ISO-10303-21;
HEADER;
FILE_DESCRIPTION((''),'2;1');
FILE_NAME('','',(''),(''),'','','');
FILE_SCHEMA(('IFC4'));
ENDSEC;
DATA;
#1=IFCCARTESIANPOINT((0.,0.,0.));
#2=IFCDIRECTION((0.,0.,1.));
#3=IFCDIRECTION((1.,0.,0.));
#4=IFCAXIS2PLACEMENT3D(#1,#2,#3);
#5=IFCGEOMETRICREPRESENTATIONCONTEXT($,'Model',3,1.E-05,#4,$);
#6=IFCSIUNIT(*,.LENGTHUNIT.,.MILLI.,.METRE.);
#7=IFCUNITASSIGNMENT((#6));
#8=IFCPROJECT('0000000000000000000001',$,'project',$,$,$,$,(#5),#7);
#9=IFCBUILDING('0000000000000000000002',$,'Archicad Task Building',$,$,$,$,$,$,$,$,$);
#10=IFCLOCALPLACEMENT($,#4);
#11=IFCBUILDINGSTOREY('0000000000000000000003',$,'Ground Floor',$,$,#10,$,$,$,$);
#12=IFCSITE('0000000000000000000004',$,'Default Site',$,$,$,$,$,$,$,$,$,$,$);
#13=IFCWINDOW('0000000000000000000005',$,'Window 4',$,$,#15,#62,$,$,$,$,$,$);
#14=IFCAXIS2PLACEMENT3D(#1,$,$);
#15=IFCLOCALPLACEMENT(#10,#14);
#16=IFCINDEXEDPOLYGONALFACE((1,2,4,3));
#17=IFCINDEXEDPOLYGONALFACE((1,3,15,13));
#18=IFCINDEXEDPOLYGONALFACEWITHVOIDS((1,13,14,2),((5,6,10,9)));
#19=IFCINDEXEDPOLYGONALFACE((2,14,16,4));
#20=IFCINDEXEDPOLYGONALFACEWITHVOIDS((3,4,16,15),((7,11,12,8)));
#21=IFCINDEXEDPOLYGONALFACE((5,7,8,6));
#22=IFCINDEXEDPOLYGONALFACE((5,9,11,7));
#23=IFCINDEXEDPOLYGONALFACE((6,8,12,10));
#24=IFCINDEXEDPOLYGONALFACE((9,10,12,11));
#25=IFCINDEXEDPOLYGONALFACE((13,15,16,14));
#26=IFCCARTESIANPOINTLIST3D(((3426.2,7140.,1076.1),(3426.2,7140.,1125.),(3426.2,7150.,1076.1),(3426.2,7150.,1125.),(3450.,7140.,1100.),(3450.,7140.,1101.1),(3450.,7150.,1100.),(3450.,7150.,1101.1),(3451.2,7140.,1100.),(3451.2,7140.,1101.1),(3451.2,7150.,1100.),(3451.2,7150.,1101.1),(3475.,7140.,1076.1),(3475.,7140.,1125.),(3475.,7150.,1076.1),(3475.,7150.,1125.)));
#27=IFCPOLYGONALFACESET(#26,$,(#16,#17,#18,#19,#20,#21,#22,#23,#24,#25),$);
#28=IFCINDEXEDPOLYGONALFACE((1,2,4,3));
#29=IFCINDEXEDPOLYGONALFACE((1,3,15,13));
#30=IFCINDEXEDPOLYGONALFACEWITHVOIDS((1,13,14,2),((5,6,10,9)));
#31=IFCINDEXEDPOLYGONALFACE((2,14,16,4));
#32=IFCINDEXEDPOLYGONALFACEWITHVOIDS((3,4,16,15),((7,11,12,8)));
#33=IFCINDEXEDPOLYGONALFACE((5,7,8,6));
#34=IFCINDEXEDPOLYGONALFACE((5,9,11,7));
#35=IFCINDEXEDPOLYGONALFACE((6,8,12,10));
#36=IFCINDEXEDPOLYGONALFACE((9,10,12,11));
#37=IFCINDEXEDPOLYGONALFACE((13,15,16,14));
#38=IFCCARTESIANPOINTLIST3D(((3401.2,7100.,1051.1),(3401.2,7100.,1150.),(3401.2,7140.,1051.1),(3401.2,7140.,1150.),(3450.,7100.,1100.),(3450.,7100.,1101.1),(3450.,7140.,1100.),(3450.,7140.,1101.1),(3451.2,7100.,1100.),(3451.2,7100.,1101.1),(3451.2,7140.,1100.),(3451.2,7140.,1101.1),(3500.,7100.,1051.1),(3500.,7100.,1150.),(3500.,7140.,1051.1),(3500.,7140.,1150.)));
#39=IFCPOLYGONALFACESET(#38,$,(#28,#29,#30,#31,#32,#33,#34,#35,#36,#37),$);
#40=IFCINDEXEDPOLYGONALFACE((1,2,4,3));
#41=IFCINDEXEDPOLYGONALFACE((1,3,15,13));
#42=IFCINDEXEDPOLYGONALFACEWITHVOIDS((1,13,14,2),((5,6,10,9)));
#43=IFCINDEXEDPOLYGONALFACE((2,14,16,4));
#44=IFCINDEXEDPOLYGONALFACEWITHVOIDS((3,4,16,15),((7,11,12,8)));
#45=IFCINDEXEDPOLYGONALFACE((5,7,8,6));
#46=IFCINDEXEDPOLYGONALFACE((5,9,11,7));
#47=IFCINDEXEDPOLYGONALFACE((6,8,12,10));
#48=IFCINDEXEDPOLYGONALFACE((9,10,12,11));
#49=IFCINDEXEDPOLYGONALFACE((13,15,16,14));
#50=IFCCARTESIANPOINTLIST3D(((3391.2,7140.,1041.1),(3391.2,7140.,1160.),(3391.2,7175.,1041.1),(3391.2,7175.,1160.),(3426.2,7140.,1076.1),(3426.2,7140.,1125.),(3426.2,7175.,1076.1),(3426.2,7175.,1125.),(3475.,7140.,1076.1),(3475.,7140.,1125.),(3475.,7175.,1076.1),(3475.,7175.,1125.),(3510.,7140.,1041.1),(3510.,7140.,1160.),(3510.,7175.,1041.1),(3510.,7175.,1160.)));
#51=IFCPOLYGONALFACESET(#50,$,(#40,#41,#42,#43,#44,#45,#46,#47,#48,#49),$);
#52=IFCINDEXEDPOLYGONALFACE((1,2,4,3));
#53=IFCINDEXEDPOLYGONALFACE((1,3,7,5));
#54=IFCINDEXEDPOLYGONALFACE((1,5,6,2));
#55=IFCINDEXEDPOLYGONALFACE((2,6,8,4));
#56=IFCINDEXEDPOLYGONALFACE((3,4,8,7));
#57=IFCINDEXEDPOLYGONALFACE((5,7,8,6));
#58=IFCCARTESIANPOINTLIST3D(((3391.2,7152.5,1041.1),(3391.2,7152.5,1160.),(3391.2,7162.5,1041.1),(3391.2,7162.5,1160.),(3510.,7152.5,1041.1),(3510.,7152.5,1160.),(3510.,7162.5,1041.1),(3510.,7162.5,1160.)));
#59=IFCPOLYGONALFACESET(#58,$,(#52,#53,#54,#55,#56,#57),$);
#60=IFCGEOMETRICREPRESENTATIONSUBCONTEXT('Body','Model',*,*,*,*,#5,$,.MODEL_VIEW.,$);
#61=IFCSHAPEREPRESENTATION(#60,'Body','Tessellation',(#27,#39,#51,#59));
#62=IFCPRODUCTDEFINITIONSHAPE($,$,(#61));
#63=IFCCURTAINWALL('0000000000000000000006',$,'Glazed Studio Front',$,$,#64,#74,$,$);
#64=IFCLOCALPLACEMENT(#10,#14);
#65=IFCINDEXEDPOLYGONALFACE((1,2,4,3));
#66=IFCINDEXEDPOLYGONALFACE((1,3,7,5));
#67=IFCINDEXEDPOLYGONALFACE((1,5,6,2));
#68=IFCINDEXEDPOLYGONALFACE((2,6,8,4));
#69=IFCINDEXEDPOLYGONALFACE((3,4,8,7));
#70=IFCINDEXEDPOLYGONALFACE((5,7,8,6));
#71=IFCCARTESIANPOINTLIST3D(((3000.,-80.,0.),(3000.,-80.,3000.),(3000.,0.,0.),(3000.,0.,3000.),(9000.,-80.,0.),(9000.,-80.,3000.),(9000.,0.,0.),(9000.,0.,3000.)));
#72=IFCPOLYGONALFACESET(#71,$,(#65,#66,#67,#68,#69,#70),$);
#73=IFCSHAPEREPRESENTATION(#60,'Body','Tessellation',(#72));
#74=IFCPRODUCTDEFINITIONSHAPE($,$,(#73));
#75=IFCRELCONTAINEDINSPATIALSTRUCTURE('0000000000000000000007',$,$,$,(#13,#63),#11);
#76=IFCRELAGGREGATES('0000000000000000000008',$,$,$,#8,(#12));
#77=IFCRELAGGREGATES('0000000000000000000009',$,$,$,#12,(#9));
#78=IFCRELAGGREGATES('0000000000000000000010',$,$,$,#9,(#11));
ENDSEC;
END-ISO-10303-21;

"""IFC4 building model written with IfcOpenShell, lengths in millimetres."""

from ifc_helpers import new_model, si_unit, frame, origin_with_axes, place, context, subcontext, project, spatial, line, indexed_curve, outline, extrude, element, save


model = new_model("IFC4")

# Units and contexts
model_context = context("Model", 3, precision=1e-05, world=origin_with_axes())
body_context = subcontext(model_context, "Body", "Model", "MODEL_VIEW")
ifc_project = project(units=[si_unit("LENGTHUNIT", "METRE", prefix="MILLI")], contexts=[model_context])

# Site, building, storey
site = spatial("IfcSite", under=ifc_project, Name="Default Site")
building = spatial("IfcBuilding", under=site, Name="Archicad Task Building")
storey_placement = place(None, origin_with_axes())
storey = spatial("IfcBuildingStorey", under=building, at=storey_placement, Name="Ground Floor")

# Window
for number, where, z_axis, x_axis, name in (
    (1, (3450.0, 7050.0, 1100.0), (0.0, 0.0, 1.0), (1.0, 0.0, 0.0), "Window 4"),
):
    element("IfcWindow", number, at=place(storey_placement, frame(where, z_axis=z_axis, x_axis=x_axis)), inside=storey, Name=name, context=body_context, shape_type="SweptSolid", body=[
        extrude(outline(indexed_curve([(0.0, 0.0), (1.2, 0.0), (1.2, 1.1), (0.0, 1.1)], segments=[line(1, 2, 3, 4, 1)]), holes=[indexed_curve([(25.0, 25.0), (-23.8, 25.0), (-23.8, -23.9), (25.0, -23.9)], segments=[line(1, 2, 3, 4, 1)])]), frame((0.0, 90.0, 0.0), z_axis=(0.0, -1.0, 0.0), x_axis=(1.0, 0.0, 0.0)), (0.0, 0.0, -1.0), 10.0),
        extrude(outline(indexed_curve([(0.0, 0.0), (1.2, 0.0), (1.2, 1.1), (0.0, 1.1)], segments=[line(1, 2, 3, 4, 1)]), holes=[indexed_curve([(50.0, 50.0), (-48.8, 50.0), (-48.8, -48.9), (50.0, -48.9)], segments=[line(1, 2, 3, 4, 1)])]), frame((0.0, 50.0, 0.0), z_axis=(0.0, -1.0, 0.0), x_axis=(1.0, 0.0, 0.0)), (0.0, 0.0, -1.0), 40.0),
        extrude(outline(indexed_curve([(0.0, 0.0), (-48.8, 0.0), (-48.8, -48.9), (0.0, -48.9)], segments=[line(1, 2, 3, 4, 1)]), holes=[indexed_curve([(35.0, 35.0), (-83.8, 35.0), (-83.8, -83.9), (35.0, -83.9)], segments=[line(1, 2, 3, 4, 1)])]), frame((25.0, 90.0, 25.0), z_axis=(0.0, -1.0, 0.0), x_axis=(1.0, 0.0, 0.0)), (0.0, 0.0, -1.0), 35.0),
        extrude(outline(indexed_curve([(35.0, 35.0), (-83.8, 35.0), (-83.8, -83.9), (35.0, -83.9)], segments=[line(1, 2, 3, 4, 1)])), frame((25.0, 102.5, 25.0), z_axis=(0.0, -1.0, 0.0), x_axis=(1.0, 0.0, 0.0)), (0.0, 0.0, -1.0), 10.0),
    ])

# Curtain wall
curtain_wall_placement = place(storey_placement, frame((3000.0, -80.0, 0.0), z_axis=(0.0, 0.0, 1.0), x_axis=(1.0, 0.0, 0.0)))
element("IfcCurtainWall", 2, at=curtain_wall_placement, inside=storey, Name="Glazed Studio Front", context=body_context, shape_type="SweptSolid", body=[
    extrude(outline(indexed_curve([(0.0, 0.0), (0.0, 80.0), (6000.0, 80.0), (6000.0, 0.0), (0.0, 0.0)], self_intersect=False)), origin_with_axes(), (0.0, 0.0, 1.0), 3000.0),
])

save(model, "model.ifc")
